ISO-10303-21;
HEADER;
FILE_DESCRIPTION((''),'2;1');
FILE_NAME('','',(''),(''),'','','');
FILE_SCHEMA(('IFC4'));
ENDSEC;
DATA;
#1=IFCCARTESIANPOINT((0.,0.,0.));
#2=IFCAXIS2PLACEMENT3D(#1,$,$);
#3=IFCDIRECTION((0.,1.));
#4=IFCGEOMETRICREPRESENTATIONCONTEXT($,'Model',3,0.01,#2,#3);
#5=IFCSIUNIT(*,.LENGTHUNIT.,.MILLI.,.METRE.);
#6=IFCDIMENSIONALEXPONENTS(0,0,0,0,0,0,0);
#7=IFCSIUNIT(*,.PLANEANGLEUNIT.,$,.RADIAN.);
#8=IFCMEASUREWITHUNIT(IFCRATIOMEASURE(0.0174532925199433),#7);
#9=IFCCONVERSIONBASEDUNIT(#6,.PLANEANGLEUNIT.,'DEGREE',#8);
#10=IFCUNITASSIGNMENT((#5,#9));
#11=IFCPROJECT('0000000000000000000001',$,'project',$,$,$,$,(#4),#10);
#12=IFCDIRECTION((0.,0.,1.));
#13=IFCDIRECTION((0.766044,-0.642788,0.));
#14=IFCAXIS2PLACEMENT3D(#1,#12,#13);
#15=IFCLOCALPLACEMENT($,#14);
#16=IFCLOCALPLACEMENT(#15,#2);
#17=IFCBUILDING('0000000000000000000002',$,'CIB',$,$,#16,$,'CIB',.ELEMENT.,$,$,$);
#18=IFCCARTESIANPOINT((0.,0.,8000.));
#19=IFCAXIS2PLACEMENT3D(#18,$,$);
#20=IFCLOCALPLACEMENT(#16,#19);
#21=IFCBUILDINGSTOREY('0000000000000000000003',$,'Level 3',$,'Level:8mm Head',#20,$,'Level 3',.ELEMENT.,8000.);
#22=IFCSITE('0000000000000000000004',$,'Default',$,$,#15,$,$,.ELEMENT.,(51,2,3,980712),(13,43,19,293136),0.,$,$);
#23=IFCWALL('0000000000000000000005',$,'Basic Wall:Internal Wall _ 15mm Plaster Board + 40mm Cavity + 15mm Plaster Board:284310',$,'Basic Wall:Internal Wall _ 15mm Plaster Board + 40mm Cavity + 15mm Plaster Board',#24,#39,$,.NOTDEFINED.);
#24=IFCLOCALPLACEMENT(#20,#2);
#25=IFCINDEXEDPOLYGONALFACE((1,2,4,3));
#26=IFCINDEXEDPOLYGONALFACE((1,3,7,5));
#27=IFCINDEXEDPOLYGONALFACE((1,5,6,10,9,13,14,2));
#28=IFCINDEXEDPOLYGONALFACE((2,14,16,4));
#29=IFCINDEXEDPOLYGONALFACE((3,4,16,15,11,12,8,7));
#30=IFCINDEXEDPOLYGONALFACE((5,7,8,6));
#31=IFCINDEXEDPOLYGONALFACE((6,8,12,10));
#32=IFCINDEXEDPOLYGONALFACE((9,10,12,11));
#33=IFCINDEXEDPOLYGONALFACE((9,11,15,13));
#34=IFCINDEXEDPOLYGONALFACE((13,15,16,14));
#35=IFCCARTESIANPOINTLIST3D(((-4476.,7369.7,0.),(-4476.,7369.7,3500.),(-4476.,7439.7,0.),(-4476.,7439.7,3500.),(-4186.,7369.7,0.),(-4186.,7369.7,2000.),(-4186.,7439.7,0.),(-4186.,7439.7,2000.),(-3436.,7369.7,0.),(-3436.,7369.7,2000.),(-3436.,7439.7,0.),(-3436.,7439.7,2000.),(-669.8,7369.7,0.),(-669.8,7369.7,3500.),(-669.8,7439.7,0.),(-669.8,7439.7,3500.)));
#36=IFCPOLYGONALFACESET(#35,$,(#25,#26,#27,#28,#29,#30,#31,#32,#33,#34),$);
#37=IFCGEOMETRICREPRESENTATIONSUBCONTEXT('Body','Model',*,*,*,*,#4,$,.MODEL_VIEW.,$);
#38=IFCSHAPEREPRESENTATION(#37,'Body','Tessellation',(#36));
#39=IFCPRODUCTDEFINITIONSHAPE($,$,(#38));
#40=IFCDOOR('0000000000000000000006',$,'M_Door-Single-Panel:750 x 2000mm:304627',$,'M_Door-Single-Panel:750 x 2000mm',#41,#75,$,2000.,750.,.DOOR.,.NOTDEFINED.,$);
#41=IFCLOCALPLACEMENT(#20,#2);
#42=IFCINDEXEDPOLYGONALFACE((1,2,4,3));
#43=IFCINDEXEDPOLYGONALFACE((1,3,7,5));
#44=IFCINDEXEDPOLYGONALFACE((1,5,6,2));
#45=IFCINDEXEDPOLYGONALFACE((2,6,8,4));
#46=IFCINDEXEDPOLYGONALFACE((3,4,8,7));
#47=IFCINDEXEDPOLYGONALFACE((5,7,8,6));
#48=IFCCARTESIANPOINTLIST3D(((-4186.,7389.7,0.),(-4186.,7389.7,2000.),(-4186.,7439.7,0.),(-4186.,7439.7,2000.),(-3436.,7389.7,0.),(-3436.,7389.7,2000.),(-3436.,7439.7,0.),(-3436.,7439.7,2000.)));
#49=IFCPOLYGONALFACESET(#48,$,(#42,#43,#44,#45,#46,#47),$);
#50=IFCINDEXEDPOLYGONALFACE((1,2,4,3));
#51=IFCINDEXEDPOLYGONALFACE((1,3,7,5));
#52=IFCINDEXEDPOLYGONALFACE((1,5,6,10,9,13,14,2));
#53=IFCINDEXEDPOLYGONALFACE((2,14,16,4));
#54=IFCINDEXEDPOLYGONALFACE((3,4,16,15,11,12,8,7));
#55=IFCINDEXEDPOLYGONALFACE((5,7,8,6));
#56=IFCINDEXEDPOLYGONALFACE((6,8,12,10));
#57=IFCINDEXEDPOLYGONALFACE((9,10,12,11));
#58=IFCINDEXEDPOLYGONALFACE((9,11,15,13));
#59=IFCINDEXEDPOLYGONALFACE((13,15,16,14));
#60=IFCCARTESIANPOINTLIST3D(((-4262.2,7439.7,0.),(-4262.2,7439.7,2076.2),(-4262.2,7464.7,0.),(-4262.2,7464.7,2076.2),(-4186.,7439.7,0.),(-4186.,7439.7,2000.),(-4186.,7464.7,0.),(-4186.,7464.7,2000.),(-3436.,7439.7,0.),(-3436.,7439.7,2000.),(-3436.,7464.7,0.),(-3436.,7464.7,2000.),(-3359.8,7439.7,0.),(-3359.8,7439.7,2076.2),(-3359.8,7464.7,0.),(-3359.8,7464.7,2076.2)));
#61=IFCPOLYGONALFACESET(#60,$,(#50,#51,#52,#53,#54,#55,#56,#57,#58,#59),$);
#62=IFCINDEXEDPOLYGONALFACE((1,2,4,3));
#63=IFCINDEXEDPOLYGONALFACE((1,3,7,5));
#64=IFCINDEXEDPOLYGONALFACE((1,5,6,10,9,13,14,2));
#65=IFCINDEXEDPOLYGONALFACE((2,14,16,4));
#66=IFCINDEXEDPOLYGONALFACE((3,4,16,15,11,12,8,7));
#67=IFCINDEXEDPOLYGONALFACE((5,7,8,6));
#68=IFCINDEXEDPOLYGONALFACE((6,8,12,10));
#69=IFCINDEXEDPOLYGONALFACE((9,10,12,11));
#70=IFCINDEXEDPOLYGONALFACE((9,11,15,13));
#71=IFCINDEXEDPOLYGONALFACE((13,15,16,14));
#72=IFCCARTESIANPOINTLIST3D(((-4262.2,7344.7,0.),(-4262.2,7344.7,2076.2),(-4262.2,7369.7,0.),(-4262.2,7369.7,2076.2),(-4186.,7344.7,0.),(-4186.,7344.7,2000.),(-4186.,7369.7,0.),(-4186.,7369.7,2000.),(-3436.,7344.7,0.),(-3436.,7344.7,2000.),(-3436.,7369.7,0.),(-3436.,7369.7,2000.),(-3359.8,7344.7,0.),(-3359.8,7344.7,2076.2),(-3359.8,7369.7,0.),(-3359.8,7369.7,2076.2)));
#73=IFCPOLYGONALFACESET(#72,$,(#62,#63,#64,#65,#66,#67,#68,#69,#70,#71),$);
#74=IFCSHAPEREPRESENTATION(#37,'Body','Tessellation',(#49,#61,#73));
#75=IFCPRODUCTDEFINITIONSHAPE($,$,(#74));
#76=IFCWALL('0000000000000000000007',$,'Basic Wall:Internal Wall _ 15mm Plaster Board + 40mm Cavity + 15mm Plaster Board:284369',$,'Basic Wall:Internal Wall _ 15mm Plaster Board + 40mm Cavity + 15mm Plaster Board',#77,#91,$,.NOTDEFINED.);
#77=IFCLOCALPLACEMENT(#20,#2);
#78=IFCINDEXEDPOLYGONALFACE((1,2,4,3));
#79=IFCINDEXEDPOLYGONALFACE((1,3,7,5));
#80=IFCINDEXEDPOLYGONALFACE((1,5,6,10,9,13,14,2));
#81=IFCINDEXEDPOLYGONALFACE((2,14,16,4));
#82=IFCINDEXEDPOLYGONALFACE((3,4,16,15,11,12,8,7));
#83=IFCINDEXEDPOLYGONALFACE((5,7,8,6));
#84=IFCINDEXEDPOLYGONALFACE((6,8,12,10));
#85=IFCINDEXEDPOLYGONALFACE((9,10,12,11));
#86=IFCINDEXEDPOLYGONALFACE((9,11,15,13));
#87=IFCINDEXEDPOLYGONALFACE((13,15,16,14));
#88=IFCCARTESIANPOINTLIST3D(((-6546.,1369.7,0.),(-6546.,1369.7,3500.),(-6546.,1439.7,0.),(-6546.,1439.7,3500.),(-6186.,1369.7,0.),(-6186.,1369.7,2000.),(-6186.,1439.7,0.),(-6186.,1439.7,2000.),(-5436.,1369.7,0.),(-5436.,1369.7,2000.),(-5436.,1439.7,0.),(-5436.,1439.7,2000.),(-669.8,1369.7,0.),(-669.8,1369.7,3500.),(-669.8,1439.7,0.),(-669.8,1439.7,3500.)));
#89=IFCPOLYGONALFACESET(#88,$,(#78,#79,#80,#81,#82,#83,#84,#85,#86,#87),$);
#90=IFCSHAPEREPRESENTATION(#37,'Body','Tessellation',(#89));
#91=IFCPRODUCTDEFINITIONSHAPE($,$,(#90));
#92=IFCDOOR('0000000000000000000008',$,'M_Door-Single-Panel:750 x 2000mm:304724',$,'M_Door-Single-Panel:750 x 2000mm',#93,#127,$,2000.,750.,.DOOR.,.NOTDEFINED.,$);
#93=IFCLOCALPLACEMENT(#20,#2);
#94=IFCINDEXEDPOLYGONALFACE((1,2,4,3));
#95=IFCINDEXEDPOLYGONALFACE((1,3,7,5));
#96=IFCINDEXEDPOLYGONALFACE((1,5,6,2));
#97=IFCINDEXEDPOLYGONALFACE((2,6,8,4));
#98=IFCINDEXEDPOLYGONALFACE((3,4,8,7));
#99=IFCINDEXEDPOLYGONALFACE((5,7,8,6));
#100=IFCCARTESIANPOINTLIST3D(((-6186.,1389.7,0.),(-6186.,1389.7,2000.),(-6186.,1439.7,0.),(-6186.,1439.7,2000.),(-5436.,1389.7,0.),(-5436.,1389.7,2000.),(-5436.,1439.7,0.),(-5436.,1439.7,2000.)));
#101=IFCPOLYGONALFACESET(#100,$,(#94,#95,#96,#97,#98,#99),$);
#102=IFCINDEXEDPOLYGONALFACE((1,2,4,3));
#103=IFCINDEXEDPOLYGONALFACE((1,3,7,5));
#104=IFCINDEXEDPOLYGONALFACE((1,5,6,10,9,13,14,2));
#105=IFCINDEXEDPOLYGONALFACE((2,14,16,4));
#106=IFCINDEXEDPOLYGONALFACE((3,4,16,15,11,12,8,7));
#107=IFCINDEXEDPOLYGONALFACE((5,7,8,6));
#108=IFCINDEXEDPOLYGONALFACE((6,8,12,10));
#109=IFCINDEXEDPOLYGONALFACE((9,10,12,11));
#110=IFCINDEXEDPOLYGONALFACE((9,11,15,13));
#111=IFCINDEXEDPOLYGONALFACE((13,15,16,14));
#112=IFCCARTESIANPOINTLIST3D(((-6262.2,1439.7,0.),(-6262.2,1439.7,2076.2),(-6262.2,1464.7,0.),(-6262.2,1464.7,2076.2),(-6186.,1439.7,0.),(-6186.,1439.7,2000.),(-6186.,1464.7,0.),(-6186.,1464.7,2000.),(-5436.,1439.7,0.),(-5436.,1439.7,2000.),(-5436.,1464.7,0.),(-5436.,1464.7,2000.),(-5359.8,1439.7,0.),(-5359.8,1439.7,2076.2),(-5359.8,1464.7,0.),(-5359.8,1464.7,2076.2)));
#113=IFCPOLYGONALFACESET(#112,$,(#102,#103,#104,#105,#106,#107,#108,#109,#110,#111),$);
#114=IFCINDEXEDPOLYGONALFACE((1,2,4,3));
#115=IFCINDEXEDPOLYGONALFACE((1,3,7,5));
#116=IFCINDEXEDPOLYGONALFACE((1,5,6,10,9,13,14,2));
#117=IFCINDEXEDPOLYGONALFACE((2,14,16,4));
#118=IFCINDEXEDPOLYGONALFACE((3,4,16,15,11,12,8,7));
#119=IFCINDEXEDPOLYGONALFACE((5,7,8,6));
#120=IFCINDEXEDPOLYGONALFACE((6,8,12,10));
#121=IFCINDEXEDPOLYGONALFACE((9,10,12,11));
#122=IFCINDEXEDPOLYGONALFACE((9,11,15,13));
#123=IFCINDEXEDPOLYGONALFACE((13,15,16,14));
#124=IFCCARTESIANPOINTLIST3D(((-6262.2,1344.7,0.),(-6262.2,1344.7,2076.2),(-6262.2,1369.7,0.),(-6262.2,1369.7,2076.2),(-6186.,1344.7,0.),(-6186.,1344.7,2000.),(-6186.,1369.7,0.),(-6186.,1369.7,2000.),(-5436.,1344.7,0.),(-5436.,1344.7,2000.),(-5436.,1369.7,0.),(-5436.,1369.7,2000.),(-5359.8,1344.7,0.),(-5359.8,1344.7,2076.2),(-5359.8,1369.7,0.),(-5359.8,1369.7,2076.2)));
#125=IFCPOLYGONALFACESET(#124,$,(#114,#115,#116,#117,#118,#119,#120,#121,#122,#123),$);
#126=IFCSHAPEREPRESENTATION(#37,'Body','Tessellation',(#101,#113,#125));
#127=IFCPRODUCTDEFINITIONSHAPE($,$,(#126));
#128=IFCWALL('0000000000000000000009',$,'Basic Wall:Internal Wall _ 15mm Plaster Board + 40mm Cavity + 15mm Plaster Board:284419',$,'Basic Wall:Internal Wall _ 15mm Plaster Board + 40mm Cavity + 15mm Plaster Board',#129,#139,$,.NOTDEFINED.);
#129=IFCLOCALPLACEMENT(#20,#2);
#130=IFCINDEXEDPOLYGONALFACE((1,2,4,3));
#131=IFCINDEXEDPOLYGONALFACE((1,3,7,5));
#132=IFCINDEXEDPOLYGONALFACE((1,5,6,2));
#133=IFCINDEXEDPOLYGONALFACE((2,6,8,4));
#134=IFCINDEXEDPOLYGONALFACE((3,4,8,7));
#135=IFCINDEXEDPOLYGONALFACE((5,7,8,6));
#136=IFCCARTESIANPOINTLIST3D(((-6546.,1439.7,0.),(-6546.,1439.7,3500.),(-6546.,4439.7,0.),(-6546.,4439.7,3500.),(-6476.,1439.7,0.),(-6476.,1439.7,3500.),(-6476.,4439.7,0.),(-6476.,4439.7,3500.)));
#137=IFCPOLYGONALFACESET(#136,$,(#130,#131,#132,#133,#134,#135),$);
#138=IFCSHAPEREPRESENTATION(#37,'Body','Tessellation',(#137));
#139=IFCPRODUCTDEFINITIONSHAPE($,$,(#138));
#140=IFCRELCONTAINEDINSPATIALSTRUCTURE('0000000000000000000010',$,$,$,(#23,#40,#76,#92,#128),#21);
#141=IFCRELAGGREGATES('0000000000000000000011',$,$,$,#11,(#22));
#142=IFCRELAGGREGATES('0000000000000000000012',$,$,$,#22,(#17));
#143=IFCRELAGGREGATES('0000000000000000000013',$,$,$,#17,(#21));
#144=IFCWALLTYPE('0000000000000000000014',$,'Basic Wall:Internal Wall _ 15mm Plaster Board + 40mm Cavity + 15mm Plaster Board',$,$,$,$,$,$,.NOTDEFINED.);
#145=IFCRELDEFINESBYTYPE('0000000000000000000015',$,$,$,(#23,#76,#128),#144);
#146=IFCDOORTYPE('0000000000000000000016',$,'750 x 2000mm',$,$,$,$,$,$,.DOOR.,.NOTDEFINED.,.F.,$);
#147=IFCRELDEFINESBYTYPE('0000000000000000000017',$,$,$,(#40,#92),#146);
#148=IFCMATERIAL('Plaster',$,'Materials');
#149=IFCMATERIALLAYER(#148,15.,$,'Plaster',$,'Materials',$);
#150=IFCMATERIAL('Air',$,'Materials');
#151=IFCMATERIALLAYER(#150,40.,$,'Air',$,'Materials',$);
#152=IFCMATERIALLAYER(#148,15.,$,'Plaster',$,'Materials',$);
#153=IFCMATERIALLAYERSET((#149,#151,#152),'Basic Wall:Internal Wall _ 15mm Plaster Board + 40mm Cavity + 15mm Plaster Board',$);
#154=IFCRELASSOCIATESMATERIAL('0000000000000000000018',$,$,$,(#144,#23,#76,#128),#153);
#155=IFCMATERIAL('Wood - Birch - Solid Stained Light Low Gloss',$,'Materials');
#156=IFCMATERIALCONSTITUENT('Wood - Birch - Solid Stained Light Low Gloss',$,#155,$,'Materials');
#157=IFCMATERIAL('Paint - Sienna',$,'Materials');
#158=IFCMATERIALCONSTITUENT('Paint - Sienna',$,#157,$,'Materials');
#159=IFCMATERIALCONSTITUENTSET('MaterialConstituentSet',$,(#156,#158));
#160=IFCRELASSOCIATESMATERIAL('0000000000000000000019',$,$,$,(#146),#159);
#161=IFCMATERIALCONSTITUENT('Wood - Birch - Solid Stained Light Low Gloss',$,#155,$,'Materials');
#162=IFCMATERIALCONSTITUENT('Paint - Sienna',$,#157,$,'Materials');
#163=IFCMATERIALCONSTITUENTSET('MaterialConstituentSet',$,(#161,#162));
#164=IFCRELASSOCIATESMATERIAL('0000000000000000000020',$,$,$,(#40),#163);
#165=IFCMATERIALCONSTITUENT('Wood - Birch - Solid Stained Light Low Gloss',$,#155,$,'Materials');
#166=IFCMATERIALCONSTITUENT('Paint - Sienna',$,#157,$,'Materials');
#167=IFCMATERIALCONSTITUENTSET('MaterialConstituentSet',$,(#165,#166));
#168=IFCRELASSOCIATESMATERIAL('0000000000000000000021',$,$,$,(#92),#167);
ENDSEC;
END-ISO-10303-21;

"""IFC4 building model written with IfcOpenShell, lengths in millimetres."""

from ifc_helpers import new_model, entity, si_unit, converted_unit, direction, frame, frame_2d, origin, origin_2d_with_axis, place, context, subcontext, project, spatial, polyline, rectangle, outline, extrude, source, transform, mapped, material, layer, layer_set, layer_usage, constituent, constituent_set, type_object, type_shapes, element, fill, save


model = new_model("IFC4")

# Units and contexts
model_context = context("Model", 3, precision=0.01, world=origin(), true_north=direction((0.0, 1.0)))
body_context = subcontext(model_context, "Body", "Model", "MODEL_VIEW")
ifc_project = project(units=[si_unit("LENGTHUNIT", "METRE", prefix="MILLI"), converted_unit("PLANEANGLEUNIT", "DEGREE", entity("IfcRatioMeasure", 0.0174532925199433), si_unit("PLANEANGLEUNIT", "RADIAN"), dimensions=[0, 0, 0, 0, 0, 0, 0])], contexts=[model_context])

# Site, building, storey
site_placement = place(None, frame((0.0, 0.0, 0.0), z_axis=(0.0, 0.0, 1.0), x_axis=(0.766044, -0.642788, 0.0)))
site = spatial("IfcSite", under=ifc_project, at=site_placement, Name="Default", CompositionType="ELEMENT", RefLatitude=(51, 2, 3, 980712), RefLongitude=(13, 43, 19, 293136), RefElevation=0.0)
building_placement = place(site_placement, origin())
building = spatial("IfcBuilding", under=site, at=building_placement, Name="CIB", LongName="CIB", CompositionType="ELEMENT")
storey_placement = place(building_placement, frame((0.0, 0.0, 8000.0)))
storey = spatial("IfcBuildingStorey", under=building, at=storey_placement, Name="Level 3", ObjectType="Level:8mm Head", LongName="Level 3", CompositionType="ELEMENT", Elevation=8000.0)

# Shared definitions
ifc_material_1 = material(Name="Plaster", Category="Materials")

# Shared definitions
ifc_layer_1 = layer(ifc_material_1, 15.0, Name="Plaster", Category="Materials")
ifc_material_2 = material(Name="Air", Category="Materials")
ifc_layer_2 = layer(ifc_material_2, 40.0, Name="Air", Category="Materials")
ifc_layer_3 = layer(ifc_material_1, 15.0, Name="Plaster", Category="Materials")
ifc_layer_set_1 = layer_set([ifc_layer_1, ifc_layer_2, ifc_layer_3], Name="Basic Wall:Internal Wall _ 15mm Plaster Board + 40mm Cavity + 15mm Plaster Board")
wall_type_1 = type_object("IfcWallType", Name="Basic Wall:Internal Wall _ 15mm Plaster Board + 40mm Cavity + 15mm Plaster Board", PredefinedType="NOTDEFINED", material=ifc_layer_set_1)

# Walls, openings, doors
ifc_layer_usage_1 = layer_usage(ifc_layer_set_1, "AXIS2", "NEGATIVE", 35.0)
wall_1_placement = place(storey_placement, frame((-4476.0, 7404.7, 0.0)))
wall_1 = element("IfcWall", 1, at=wall_1_placement, inside=storey, type_object=wall_type_1, material=ifc_layer_usage_1, Name="Basic Wall:Internal Wall _ 15mm Plaster Board + 40mm Cavity + 15mm Plaster Board:284310", ObjectType="Basic Wall:Internal Wall _ 15mm Plaster Board + 40mm Cavity + 15mm Plaster Board", PredefinedType="NOTDEFINED", context=body_context, shape_type="SweptSolid", body=[
    extrude(rectangle(XDim=3806.3, YDim=70.0, at=frame_2d((1903.1, 0.0), x_axis=(-1.0, 0.0))), origin(), (0.0, 0.0, 1.0), 3500.0),
])
opening_1_placement = place(wall_1_placement, frame((290.0, -35.0, 0.0)))
opening_1 = element("IfcOpeningElement", 2, at=opening_1_placement, cuts=wall_1, ObjectType="Opening", PredefinedType="OPENING", context=body_context, shape_type="SweptSolid", body=[
    extrude(rectangle(XDim=750.0, YDim=2000.0, at=frame_2d((1000.0, 375.0), x_axis=(0.0, -1.0))), frame((0.0, 0.0, 0.0), z_axis=(0.0, 1.0, 0.0), x_axis=(0.0, 0.0, 1.0)), (0.0, 0.0, 1.0), 70.0),
])
ifc_material_3 = material(Name="Wood - Birch - Solid Stained Light Low Gloss", Category="Materials")
ifc_constituent_1 = constituent(ifc_material_3, Name="Wood - Birch - Solid Stained Light Low Gloss", Category="Materials")
ifc_material_4 = material(Name="Paint - Sienna", Category="Materials")
ifc_constituent_2 = constituent(ifc_material_4, Name="Paint - Sienna", Category="Materials")
ifc_constituent_set_1 = constituent_set(constituents=[ifc_constituent_1, ifc_constituent_2], Name="MaterialConstituentSet")
ifc_constituent_3 = constituent(ifc_material_3, Name="Wood - Birch - Solid Stained Light Low Gloss", Category="Materials")
ifc_constituent_4 = constituent(ifc_material_4, Name="Paint - Sienna", Category="Materials")
ifc_constituent_set_2 = constituent_set(constituents=[ifc_constituent_3, ifc_constituent_4], Name="MaterialConstituentSet")
door_type = type_object("IfcDoorType", Name="750 x 2000mm", OperationType="NOTDEFINED", ParameterTakesPrecedence=False, PredefinedType="DOOR", material=ifc_constituent_set_2)
shared_shape = source(origin(), body_context, "Body", "SweptSolid", [
    extrude(rectangle(XDim=750.0, YDim=50.0, at=origin_2d_with_axis()), frame((375.0, 45.0, 0.0)), (0.0, 0.0, 1.0), 2000.0),
    extrude(outline(polyline([(-451.2, -1057.2), (451.2, -1057.2), (451.2, 1019.0), (375.0, 1019.0), (375.0, -981.0), (-375.0, -981.0), (-375.0, 1019.0), (-451.2, 1019.0), (-451.2, -1057.2)])), frame((375.0, 95.0, 1019.0), z_axis=(0.0, -1.0, 0.0), x_axis=(-1.0, 0.0, 0.0)), (0.0, 0.0, 1.0), 25.0),
    extrude(outline(polyline([(-1057.2, -451.2), (1019.0, -451.2), (1019.0, -375.0), (-981.0, -375.0), (-981.0, 375.0), (1019.0, 375.0), (1019.0, 451.2), (-1057.2, 451.2), (-1057.2, -451.2)])), frame((375.0, 0.0, 1019.0), z_axis=(0.0, -1.0, 0.0), x_axis=(0.0, 0.0, -1.0)), (0.0, 0.0, 1.0), 25.0),
])
type_shapes(door_type, [shared_shape])
door_1_placement = place(opening_1_placement, origin())
door_1 = element("IfcDoor", 3, at=door_1_placement, inside=storey, type_object=door_type, material=ifc_constituent_set_1, Name="M_Door-Single-Panel:750 x 2000mm:304627", ObjectType="M_Door-Single-Panel:750 x 2000mm", OperationType="NOTDEFINED", OverallHeight=2000.0, OverallWidth=750.0, PredefinedType="DOOR", context=body_context, shape_type="MappedRepresentation", body=[
    mapped(shared_shape, transform((0.0, 0.0, 0.0), scale=1.0)),
])
fill(opening_1, door_1)
ifc_layer_usage_2 = layer_usage(ifc_layer_set_1, "AXIS2", "NEGATIVE", 35.0)
wall_2_placement = place(storey_placement, frame((-669.8, 1404.7, 0.0), z_axis=(0.0, 0.0, 1.0), x_axis=(-1.0, 0.0, 0.0)))
wall_2 = element("IfcWall", 4, at=wall_2_placement, inside=storey, type_object=wall_type_1, material=ifc_layer_usage_2, Name="Basic Wall:Internal Wall _ 15mm Plaster Board + 40mm Cavity + 15mm Plaster Board:284369", ObjectType="Basic Wall:Internal Wall _ 15mm Plaster Board + 40mm Cavity + 15mm Plaster Board", PredefinedType="NOTDEFINED", context=body_context, shape_type="SweptSolid", body=[
    extrude(rectangle(XDim=5876.2, YDim=70.0, at=frame_2d((2938.1, 0.0), x_axis=(-1.0, 0.0))), origin(), (0.0, 0.0, 1.0), 3500.0),
])
opening_2_placement = place(wall_2_placement, frame((5516.2, 35.0, 0.0)))
opening_2 = element("IfcOpeningElement", 5, at=opening_2_placement, cuts=wall_2, ObjectType="Opening", PredefinedType="OPENING", context=body_context, shape_type="SweptSolid", body=[
    extrude(rectangle(XDim=750.0, YDim=2000.0, at=frame_2d((1000.0, 375.0), x_axis=(0.0, -1.0))), frame((0.0, 0.0, 0.0), z_axis=(0.0, -1.0, 0.0), x_axis=(0.0, 0.0, 1.0)), (0.0, 0.0, 1.0), 70.0),
])
ifc_constituent_5 = constituent(ifc_material_3, Name="Wood - Birch - Solid Stained Light Low Gloss", Category="Materials")
ifc_constituent_6 = constituent(ifc_material_4, Name="Paint - Sienna", Category="Materials")
ifc_constituent_set_3 = constituent_set(constituents=[ifc_constituent_5, ifc_constituent_6], Name="MaterialConstituentSet")
door_2_placement = place(opening_2_placement, frame((0.0, 0.0, 0.0), z_axis=(0.0, 0.0, 1.0), x_axis=(-1.0, 0.0, 0.0)))
door_2 = element("IfcDoor", 6, at=door_2_placement, inside=storey, type_object=door_type, material=ifc_constituent_set_3, Name="M_Door-Single-Panel:750 x 2000mm:304724", ObjectType="M_Door-Single-Panel:750 x 2000mm", OperationType="NOTDEFINED", OverallHeight=2000.0, OverallWidth=750.0, PredefinedType="DOOR", context=body_context, shape_type="MappedRepresentation", body=[
    mapped(shared_shape, transform((0.0, 0.0, 0.0), scale=1.0)),
])
fill(opening_2, door_2)

# Wall
ifc_layer_usage_3 = layer_usage(ifc_layer_set_1, "AXIS2", "NEGATIVE", 35.0)
wall_3_placement = place(storey_placement, frame((-6511.0, 1439.7, 0.0), z_axis=(0.0, 0.0, 1.0), x_axis=(0.0, 1.0, 0.0)))
element("IfcWall", 7, at=wall_3_placement, inside=storey, type_object=wall_type_1, material=ifc_layer_usage_3, Name="Basic Wall:Internal Wall _ 15mm Plaster Board + 40mm Cavity + 15mm Plaster Board:284419", ObjectType="Basic Wall:Internal Wall _ 15mm Plaster Board + 40mm Cavity + 15mm Plaster Board", PredefinedType="NOTDEFINED", context=body_context, shape_type="SweptSolid", body=[
    extrude(rectangle(XDim=3000.0, YDim=70.0, at=frame_2d((1500.0, 0.0), x_axis=(-1.0, 0.0))), origin(), (0.0, 0.0, 1.0), 3500.0),
])

save(model, "model.ifc")
